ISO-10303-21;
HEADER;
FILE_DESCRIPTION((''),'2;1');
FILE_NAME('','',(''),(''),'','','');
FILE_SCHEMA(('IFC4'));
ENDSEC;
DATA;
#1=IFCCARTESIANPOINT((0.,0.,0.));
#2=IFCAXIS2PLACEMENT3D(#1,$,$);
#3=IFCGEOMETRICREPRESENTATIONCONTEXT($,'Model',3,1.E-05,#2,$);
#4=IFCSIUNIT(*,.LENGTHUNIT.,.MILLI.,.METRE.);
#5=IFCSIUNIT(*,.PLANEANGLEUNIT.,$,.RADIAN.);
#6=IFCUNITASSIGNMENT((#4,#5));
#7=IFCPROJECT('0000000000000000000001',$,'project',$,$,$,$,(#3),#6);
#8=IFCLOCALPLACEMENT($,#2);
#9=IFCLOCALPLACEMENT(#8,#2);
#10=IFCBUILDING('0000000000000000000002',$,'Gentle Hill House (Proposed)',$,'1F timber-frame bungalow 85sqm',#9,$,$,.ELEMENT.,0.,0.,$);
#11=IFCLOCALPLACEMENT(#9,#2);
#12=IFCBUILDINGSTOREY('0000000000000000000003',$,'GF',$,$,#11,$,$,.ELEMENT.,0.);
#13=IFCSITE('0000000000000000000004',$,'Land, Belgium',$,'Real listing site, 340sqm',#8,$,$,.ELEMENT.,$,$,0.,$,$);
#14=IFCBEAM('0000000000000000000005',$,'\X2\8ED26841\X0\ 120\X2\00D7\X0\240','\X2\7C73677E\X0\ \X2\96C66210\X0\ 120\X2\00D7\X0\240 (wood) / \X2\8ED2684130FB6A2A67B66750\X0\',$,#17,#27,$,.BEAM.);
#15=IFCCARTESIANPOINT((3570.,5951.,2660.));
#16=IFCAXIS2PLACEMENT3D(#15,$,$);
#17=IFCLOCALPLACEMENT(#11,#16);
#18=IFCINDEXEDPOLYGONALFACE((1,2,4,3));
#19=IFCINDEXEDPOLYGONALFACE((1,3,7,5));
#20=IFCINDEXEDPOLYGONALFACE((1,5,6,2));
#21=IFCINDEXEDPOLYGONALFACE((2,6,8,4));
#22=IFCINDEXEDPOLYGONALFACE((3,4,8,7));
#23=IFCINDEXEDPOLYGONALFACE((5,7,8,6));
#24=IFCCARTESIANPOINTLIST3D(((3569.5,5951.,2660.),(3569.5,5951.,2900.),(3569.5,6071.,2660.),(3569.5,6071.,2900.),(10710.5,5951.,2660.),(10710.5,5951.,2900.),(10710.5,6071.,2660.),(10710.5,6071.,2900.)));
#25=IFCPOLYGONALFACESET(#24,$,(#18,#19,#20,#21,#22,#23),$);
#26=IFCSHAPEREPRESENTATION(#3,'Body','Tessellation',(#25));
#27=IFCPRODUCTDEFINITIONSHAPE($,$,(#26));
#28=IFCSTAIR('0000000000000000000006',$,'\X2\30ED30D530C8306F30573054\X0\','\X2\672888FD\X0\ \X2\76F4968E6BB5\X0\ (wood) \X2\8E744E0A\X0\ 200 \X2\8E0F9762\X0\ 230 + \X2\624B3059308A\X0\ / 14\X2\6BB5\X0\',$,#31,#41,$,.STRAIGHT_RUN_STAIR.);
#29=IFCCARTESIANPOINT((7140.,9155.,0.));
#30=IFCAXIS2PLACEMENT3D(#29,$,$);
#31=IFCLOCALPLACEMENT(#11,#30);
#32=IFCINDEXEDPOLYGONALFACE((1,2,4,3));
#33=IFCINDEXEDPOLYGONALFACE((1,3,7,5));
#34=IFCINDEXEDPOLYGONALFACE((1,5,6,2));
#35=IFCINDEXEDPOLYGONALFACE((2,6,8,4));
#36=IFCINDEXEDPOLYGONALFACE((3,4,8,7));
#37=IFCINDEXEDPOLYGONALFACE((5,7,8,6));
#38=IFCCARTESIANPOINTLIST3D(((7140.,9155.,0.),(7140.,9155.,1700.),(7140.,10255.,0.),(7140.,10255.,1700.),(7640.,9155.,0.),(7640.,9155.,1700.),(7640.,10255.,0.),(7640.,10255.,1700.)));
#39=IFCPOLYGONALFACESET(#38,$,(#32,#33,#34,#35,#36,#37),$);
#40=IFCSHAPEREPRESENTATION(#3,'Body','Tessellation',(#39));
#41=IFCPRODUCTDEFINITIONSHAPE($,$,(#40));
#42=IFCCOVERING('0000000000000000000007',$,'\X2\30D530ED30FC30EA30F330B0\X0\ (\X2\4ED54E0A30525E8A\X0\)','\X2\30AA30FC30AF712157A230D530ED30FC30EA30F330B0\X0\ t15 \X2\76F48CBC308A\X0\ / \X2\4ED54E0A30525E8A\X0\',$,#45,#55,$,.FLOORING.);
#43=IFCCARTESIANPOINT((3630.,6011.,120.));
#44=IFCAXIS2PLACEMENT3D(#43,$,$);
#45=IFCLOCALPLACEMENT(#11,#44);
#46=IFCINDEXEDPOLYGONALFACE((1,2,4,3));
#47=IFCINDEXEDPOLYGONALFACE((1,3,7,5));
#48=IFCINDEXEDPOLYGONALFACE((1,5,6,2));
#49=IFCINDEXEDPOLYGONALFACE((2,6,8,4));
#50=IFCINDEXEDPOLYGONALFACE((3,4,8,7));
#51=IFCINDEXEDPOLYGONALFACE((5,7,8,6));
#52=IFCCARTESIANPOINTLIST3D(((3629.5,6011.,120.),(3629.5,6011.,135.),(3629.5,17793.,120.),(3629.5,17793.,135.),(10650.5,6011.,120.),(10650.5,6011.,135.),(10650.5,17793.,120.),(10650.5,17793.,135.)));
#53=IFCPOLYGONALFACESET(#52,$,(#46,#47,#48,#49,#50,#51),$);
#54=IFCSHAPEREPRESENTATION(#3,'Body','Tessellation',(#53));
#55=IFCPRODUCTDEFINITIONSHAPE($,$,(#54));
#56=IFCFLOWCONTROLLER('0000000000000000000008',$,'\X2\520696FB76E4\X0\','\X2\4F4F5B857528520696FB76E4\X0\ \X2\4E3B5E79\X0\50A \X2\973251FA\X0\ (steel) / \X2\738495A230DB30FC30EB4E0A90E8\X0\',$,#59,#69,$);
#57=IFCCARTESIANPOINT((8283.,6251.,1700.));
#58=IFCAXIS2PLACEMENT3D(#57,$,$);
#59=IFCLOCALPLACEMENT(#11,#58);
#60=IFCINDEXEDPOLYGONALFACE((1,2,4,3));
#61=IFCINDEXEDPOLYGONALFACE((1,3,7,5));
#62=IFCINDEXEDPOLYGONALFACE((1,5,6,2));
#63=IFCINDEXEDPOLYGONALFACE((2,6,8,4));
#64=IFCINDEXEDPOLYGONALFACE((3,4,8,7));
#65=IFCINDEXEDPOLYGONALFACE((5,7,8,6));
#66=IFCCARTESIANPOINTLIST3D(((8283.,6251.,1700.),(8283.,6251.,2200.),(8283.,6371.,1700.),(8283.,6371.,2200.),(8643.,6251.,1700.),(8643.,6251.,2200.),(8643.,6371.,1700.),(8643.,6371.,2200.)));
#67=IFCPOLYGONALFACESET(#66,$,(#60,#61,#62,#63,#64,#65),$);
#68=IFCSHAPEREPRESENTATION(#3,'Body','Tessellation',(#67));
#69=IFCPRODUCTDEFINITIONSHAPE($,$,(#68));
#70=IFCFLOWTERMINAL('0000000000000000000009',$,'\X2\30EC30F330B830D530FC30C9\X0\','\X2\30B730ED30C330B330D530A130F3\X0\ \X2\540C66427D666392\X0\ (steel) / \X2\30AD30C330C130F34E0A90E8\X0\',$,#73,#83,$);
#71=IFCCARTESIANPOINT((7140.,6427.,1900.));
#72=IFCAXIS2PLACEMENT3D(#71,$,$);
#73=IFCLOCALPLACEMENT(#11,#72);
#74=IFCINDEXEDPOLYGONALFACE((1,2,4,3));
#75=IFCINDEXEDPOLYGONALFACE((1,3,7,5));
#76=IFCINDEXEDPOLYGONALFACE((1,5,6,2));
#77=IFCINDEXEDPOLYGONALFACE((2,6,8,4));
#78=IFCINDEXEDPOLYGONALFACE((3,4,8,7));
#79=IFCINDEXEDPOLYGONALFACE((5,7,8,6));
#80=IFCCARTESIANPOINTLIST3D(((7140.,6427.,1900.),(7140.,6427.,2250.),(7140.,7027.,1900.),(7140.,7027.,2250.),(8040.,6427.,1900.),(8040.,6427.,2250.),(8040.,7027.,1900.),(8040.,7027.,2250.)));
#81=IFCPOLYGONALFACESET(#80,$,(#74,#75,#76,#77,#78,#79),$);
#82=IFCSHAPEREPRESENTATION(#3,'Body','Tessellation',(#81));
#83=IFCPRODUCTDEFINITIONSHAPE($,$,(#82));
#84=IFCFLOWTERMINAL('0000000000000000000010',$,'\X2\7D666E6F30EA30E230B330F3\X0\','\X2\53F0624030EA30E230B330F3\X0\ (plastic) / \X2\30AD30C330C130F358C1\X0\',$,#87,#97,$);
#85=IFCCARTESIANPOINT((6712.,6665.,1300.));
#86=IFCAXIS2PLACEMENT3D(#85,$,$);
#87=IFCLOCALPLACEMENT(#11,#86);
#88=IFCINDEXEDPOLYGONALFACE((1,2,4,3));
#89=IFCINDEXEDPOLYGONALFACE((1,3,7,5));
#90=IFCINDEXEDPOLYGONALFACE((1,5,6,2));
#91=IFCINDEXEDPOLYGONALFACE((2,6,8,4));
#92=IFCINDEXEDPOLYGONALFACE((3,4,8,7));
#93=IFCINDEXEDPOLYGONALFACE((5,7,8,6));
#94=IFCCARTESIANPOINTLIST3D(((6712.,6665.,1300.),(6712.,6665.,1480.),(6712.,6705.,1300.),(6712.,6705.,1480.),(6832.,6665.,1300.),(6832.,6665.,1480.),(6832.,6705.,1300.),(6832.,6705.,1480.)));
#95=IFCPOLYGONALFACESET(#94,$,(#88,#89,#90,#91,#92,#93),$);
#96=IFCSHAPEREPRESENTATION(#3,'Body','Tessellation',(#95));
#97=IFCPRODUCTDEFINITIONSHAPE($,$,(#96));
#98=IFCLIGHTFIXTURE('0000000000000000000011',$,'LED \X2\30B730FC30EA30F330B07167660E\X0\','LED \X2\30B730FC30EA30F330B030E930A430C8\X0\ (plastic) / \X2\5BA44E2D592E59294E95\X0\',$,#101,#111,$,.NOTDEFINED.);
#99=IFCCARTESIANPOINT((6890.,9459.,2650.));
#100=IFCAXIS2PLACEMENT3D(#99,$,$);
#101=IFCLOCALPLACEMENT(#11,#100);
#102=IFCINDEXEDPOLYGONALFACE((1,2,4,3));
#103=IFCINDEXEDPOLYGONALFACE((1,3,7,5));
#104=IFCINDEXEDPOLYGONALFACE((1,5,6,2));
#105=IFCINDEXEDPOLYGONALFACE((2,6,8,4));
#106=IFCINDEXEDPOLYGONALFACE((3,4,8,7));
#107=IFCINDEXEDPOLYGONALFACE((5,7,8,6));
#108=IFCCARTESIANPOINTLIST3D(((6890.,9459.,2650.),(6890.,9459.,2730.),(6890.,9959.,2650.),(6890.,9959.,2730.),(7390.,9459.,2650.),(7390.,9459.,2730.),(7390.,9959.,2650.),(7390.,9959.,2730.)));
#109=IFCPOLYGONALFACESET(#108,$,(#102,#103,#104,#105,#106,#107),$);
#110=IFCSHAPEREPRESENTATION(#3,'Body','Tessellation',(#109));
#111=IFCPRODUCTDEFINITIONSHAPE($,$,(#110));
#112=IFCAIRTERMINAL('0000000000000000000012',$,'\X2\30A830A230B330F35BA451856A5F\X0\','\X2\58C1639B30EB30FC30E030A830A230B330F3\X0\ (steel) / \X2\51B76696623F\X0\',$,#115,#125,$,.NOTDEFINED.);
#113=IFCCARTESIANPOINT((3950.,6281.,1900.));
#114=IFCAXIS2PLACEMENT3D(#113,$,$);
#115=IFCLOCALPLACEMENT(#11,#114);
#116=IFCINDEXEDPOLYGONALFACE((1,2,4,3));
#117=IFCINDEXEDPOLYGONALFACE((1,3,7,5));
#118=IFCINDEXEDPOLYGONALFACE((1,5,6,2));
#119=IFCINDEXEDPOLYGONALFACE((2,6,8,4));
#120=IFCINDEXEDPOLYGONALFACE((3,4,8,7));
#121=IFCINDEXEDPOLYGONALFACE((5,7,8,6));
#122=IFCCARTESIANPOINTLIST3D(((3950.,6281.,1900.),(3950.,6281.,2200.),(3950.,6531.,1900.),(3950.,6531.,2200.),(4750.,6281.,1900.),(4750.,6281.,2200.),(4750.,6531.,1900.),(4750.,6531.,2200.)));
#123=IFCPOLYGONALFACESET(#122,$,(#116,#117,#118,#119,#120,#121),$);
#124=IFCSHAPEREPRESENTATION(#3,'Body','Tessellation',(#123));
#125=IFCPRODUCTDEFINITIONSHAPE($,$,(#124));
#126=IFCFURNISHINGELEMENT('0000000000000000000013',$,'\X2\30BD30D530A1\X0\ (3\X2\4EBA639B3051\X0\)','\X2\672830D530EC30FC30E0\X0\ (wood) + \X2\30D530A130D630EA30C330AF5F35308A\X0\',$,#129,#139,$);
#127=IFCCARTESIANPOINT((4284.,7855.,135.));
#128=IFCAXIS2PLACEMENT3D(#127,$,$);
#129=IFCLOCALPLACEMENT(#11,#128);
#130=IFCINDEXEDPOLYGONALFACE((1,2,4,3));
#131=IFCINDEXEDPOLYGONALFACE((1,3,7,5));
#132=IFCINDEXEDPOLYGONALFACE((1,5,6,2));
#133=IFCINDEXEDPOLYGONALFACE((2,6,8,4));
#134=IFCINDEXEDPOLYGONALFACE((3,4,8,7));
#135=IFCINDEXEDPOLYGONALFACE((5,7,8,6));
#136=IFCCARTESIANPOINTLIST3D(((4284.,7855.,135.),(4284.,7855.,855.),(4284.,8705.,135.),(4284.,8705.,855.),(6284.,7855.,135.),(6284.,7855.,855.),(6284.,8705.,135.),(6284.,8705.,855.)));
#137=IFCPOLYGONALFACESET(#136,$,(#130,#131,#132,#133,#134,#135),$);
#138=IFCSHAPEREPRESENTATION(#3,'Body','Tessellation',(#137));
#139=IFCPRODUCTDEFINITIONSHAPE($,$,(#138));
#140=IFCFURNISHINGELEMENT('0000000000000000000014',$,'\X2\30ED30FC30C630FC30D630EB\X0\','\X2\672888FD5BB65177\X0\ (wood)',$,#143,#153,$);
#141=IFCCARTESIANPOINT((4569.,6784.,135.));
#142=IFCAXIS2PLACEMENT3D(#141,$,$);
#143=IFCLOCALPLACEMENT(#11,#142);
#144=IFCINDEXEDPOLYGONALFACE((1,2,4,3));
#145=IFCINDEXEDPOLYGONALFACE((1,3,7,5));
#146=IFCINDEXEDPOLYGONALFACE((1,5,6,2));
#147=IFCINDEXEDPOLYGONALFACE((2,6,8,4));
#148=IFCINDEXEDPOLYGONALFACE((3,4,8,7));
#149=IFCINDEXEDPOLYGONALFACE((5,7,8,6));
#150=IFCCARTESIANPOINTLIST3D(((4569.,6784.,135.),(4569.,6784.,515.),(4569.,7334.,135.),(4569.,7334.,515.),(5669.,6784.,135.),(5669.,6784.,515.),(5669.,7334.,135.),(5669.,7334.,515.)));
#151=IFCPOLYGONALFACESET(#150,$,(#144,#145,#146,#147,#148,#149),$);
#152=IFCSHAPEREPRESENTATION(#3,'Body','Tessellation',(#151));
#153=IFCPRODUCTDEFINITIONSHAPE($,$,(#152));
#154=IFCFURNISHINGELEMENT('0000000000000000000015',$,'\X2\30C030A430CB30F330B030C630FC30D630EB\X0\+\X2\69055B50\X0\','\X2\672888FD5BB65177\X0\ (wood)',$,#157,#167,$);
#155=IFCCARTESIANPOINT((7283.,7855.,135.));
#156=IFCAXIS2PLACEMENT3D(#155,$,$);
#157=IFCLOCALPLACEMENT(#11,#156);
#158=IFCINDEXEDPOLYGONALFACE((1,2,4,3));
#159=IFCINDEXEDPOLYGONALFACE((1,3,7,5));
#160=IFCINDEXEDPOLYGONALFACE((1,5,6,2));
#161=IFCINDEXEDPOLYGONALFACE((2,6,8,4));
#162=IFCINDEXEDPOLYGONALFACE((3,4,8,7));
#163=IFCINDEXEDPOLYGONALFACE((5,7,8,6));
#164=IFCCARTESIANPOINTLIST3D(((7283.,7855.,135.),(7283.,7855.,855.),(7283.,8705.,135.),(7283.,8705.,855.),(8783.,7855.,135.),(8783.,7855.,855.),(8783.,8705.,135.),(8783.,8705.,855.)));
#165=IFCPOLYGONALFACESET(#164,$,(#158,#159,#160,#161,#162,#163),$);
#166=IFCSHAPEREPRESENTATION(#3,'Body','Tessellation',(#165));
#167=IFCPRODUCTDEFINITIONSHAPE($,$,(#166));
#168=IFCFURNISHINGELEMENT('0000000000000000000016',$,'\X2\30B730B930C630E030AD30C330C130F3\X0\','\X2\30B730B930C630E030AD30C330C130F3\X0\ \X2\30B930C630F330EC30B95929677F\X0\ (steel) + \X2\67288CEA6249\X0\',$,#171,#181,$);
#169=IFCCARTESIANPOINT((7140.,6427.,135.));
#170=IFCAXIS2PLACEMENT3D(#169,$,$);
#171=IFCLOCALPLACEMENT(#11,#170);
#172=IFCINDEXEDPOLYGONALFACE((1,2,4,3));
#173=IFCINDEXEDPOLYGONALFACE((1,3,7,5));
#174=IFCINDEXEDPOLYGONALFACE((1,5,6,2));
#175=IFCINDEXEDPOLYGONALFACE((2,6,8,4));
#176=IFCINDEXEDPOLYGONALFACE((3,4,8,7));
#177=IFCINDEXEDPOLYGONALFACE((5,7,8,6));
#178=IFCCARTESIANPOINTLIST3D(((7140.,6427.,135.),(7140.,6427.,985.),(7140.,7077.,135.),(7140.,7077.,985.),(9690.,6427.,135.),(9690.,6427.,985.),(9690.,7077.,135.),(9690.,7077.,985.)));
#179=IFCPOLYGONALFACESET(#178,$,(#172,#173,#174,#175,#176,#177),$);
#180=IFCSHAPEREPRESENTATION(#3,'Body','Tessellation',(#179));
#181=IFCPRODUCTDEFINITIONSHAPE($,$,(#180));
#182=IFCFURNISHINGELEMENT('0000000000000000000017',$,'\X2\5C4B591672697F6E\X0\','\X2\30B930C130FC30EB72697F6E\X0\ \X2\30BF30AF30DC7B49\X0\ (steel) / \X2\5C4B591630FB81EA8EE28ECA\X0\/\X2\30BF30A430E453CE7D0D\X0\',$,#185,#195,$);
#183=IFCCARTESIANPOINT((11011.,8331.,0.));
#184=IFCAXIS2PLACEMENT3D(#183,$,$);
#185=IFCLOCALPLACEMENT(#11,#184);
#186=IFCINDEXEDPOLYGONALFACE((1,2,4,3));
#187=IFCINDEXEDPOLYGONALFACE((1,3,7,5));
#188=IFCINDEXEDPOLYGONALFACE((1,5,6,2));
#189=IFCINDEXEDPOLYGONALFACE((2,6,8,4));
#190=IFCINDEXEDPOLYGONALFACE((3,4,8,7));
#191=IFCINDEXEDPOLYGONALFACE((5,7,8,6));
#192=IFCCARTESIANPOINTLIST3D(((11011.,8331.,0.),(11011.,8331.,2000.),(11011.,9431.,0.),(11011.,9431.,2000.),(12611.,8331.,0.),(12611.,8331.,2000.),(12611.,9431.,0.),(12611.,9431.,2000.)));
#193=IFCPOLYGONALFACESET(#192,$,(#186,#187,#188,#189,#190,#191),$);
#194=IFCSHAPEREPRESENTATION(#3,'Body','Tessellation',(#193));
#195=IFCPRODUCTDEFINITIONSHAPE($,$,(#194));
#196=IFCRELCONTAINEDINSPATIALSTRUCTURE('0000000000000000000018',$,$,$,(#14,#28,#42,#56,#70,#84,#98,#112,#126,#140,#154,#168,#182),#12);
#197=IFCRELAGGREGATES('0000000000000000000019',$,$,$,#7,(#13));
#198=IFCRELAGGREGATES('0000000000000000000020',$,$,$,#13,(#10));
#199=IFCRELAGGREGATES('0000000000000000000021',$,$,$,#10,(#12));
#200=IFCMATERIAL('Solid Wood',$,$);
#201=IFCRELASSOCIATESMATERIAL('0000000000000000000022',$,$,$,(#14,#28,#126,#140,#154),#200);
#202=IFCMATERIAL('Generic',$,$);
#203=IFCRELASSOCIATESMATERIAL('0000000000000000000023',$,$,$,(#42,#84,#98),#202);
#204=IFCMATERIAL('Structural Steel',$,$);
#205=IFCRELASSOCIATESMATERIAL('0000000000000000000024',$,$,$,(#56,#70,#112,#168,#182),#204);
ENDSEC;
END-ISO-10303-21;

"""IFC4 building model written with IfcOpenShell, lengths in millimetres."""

from ifc_helpers import new_model, si_unit, frame, frame_2d, origin, place, context, project, spatial, rectangle, extrude, material, element, save


model = new_model("IFC4")

# Units and contexts
model_context = context("Model", 3, precision=1e-05, world=origin())
ifc_project = project(units=[si_unit("LENGTHUNIT", "METRE", prefix="MILLI"), si_unit("PLANEANGLEUNIT", "RADIAN")], contexts=[model_context])

# Site, building, storey
site_placement = place(None, origin())
site = spatial("IfcSite", under=ifc_project, at=site_placement, Name="Land, Belgium", ObjectType="Real listing site, 340sqm", CompositionType="ELEMENT", RefElevation=0.0)
building_placement = place(site_placement, origin())
building = spatial("IfcBuilding", under=site, at=building_placement, Name="Gentle Hill House (Proposed)", ObjectType="1F timber-frame bungalow 85sqm", CompositionType="ELEMENT", ElevationOfRefHeight=0.0, ElevationOfTerrain=0.0)
storey_placement = place(building_placement, origin())
storey = spatial("IfcBuildingStorey", under=building, at=storey_placement, Name="GF", CompositionType="ELEMENT", Elevation=0.0)

# Shared definitions
ifc_material_1 = material(Name="Solid Wood")

# Beam
beam_1_placement = place(storey_placement, frame((3570.0, 5951.0, 2660.0)))
element("IfcBeam", 1, at=beam_1_placement, inside=storey, material=ifc_material_1, Name="軒桁 120×240", Description="米松 集成 120×240 (wood) / 軒桁・横架材", PredefinedType="BEAM", context=model_context, shape_type="SweptSolid", body=[
    extrude(rectangle(XDim=7141.0, YDim=120.0, at=frame_2d((3570.0, 60.0))), frame((3570.0, 5951.0, 2660.0)), (0.0, 0.0, 1.0), 240.0),
])

# Stair
stair_placement = place(storey_placement, frame((7140.0, 9155.0, 0.0)))
element("IfcStair", 2, at=stair_placement, inside=storey, material=ifc_material_1, Name="ロフトはしご", Description="木製 直階段 (wood) 蹴上 200 踏面 230 + 手すり / 14段", PredefinedType="STRAIGHT_RUN_STAIR", context=model_context, shape_type="SweptSolid", body=[
    extrude(rectangle(XDim=500.0, YDim=1100.0, at=frame_2d((250.0, 550.0))), frame((7140.0, 9155.0, 0.0)), (0.0, 0.0, 1.0), 1700.0),
])

# Covering
ifc_material_2 = material(Name="Generic")
covering_placement = place(storey_placement, frame((3630.0, 6011.0, 120.0)))
element("IfcCovering", 3, at=covering_placement, inside=storey, material=ifc_material_2, Name="フローリング (仕上げ床)", Description="オーク無垢フローリング t15 直貼り / 仕上げ床", PredefinedType="FLOORING", context=model_context, shape_type="SweptSolid", body=[
    extrude(rectangle(XDim=7021.0, YDim=11782.0, at=frame_2d((3510.0, 5891.0))), frame((3630.0, 6011.0, 120.0)), (0.0, 0.0, 1.0), 15.0),
])

# Flow controller
ifc_material_3 = material(Name="Structural Steel")
flow_controller_placement = place(storey_placement, frame((8283.0, 6251.0, 1700.0)))
element("IfcFlowController", 4, at=flow_controller_placement, inside=storey, material=ifc_material_3, Name="分電盤", Description="住宅用分電盤 主幹50A 露出 (steel) / 玄関ホール上部", context=model_context, shape_type="SweptSolid", body=[
    extrude(rectangle(XDim=360.0, YDim=120.0, at=frame_2d((180.0, 60.0))), frame((8283.0, 6251.0, 1700.0)), (0.0, 0.0, 1.0), 500.0),
])

# Flow terminals
flow_terminal_1_placement = place(storey_placement, frame((7140.0, 6427.0, 1900.0)))
element("IfcFlowTerminal", 5, at=flow_terminal_1_placement, inside=storey, material=ifc_material_3, Name="レンジフード", Description="シロッコファン 同時給排 (steel) / キッチン上部", context=model_context, shape_type="SweptSolid", body=[
    extrude(rectangle(XDim=900.0, YDim=600.0, at=frame_2d((450.0, 300.0))), frame((7140.0, 6427.0, 1900.0)), (0.0, 0.0, 1.0), 350.0),
])
flow_terminal_2_placement = place(storey_placement, frame((6712.0, 6665.0, 1300.0)))
element("IfcFlowTerminal", 6, at=flow_terminal_2_placement, inside=storey, material=ifc_material_2, Name="給湯リモコン", Description="台所リモコン (plastic) / キッチン壁", context=model_context, shape_type="SweptSolid", body=[
    extrude(rectangle(XDim=120.0, YDim=40.0, at=frame_2d((60.0, 20.0))), frame((6712.0, 6665.0, 1300.0)), (0.0, 0.0, 1.0), 180.0),
])

# Light fixture
light_fixture_placement = place(storey_placement, frame((6890.0, 9459.0, 2650.0)))
element("IfcLightFixture", 7, at=light_fixture_placement, inside=storey, material=ifc_material_2, Name="LED シーリング照明", Description="LED シーリングライト (plastic) / 室中央天井", PredefinedType="NOTDEFINED", context=model_context, shape_type="SweptSolid", body=[
    extrude(rectangle(XDim=500.0, YDim=500.0, at=frame_2d((250.0, 250.0))), frame((6890.0, 9459.0, 2650.0)), (0.0, 0.0, 1.0), 80.0),
])

# Air terminal
air_terminal_placement = place(storey_placement, frame((3950.0, 6281.0, 1900.0)))
element("IfcAirTerminal", 8, at=air_terminal_placement, inside=storey, material=ifc_material_3, Name="エアコン室内機", Description="壁掛ルームエアコン (steel) / 冷暖房", PredefinedType="NOTDEFINED", context=model_context, shape_type="SweptSolid", body=[
    extrude(rectangle(XDim=800.0, YDim=250.0, at=frame_2d((400.0, 125.0))), frame((3950.0, 6281.0, 1900.0)), (0.0, 0.0, 1.0), 300.0),
])

# Furnishing elements
furnishing_1_placement = place(storey_placement, frame((4284.0, 7855.0, 135.0)))
element("IfcFurnishingElement", 9, at=furnishing_1_placement, inside=storey, material=ifc_material_1, Name="ソファ (3人掛け)", Description="木フレーム (wood) + ファブリック張り", context=model_context, shape_type="SweptSolid", body=[
    extrude(rectangle(XDim=2000.0, YDim=850.0, at=frame_2d((1000.0, 425.0))), frame((4284.0, 7855.0, 135.0)), (0.0, 0.0, 1.0), 720.0),
])
furnishing_2_placement = place(storey_placement, frame((4569.0, 6784.0, 135.0)))
element("IfcFurnishingElement", 10, at=furnishing_2_placement, inside=storey, material=ifc_material_1, Name="ローテーブル", Description="木製家具 (wood)", context=model_context, shape_type="SweptSolid", body=[
    extrude(rectangle(XDim=1100.0, YDim=550.0, at=frame_2d((550.0, 275.0))), frame((4569.0, 6784.0, 135.0)), (0.0, 0.0, 1.0), 380.0),
])
furnishing_3_placement = place(storey_placement, frame((7283.0, 7855.0, 135.0)))
element("IfcFurnishingElement", 11, at=furnishing_3_placement, inside=storey, material=ifc_material_1, Name="ダイニングテーブル+椅子", Description="木製家具 (wood)", context=model_context, shape_type="SweptSolid", body=[
    extrude(rectangle(XDim=1500.0, YDim=850.0, at=frame_2d((750.0, 425.0))), frame((7283.0, 7855.0, 135.0)), (0.0, 0.0, 1.0), 720.0),
])
furnishing_4_placement = place(storey_placement, frame((7140.0, 6427.0, 135.0)))
element("IfcFurnishingElement", 12, at=furnishing_4_placement, inside=storey, material=ifc_material_3, Name="システムキッチン", Description="システムキッチン ステンレス天板 (steel) + 木質扉", context=model_context, shape_type="SweptSolid", body=[
    extrude(rectangle(XDim=2550.0, YDim=650.0, at=frame_2d((1275.0, 325.0))), frame((7140.0, 6427.0, 135.0)), (0.0, 0.0, 1.0), 850.0),
])
furnishing_5_placement = place(storey_placement, frame((11011.0, 8331.0, 0.0)))
element("IfcFurnishingElement", 13, at=furnishing_5_placement, inside=storey, material=ifc_material_3, Name="屋外物置", Description="スチール物置 タクボ等 (steel) / 屋外・自転車/タイヤ収納", context=model_context, shape_type="SweptSolid", body=[
    extrude(rectangle(XDim=1600.0, YDim=1100.0, at=frame_2d((800.0, 550.0))), frame((11011.0, 8331.0, 0.0)), (0.0, 0.0, 1.0), 2000.0),
])

save(model, "model.ifc")
